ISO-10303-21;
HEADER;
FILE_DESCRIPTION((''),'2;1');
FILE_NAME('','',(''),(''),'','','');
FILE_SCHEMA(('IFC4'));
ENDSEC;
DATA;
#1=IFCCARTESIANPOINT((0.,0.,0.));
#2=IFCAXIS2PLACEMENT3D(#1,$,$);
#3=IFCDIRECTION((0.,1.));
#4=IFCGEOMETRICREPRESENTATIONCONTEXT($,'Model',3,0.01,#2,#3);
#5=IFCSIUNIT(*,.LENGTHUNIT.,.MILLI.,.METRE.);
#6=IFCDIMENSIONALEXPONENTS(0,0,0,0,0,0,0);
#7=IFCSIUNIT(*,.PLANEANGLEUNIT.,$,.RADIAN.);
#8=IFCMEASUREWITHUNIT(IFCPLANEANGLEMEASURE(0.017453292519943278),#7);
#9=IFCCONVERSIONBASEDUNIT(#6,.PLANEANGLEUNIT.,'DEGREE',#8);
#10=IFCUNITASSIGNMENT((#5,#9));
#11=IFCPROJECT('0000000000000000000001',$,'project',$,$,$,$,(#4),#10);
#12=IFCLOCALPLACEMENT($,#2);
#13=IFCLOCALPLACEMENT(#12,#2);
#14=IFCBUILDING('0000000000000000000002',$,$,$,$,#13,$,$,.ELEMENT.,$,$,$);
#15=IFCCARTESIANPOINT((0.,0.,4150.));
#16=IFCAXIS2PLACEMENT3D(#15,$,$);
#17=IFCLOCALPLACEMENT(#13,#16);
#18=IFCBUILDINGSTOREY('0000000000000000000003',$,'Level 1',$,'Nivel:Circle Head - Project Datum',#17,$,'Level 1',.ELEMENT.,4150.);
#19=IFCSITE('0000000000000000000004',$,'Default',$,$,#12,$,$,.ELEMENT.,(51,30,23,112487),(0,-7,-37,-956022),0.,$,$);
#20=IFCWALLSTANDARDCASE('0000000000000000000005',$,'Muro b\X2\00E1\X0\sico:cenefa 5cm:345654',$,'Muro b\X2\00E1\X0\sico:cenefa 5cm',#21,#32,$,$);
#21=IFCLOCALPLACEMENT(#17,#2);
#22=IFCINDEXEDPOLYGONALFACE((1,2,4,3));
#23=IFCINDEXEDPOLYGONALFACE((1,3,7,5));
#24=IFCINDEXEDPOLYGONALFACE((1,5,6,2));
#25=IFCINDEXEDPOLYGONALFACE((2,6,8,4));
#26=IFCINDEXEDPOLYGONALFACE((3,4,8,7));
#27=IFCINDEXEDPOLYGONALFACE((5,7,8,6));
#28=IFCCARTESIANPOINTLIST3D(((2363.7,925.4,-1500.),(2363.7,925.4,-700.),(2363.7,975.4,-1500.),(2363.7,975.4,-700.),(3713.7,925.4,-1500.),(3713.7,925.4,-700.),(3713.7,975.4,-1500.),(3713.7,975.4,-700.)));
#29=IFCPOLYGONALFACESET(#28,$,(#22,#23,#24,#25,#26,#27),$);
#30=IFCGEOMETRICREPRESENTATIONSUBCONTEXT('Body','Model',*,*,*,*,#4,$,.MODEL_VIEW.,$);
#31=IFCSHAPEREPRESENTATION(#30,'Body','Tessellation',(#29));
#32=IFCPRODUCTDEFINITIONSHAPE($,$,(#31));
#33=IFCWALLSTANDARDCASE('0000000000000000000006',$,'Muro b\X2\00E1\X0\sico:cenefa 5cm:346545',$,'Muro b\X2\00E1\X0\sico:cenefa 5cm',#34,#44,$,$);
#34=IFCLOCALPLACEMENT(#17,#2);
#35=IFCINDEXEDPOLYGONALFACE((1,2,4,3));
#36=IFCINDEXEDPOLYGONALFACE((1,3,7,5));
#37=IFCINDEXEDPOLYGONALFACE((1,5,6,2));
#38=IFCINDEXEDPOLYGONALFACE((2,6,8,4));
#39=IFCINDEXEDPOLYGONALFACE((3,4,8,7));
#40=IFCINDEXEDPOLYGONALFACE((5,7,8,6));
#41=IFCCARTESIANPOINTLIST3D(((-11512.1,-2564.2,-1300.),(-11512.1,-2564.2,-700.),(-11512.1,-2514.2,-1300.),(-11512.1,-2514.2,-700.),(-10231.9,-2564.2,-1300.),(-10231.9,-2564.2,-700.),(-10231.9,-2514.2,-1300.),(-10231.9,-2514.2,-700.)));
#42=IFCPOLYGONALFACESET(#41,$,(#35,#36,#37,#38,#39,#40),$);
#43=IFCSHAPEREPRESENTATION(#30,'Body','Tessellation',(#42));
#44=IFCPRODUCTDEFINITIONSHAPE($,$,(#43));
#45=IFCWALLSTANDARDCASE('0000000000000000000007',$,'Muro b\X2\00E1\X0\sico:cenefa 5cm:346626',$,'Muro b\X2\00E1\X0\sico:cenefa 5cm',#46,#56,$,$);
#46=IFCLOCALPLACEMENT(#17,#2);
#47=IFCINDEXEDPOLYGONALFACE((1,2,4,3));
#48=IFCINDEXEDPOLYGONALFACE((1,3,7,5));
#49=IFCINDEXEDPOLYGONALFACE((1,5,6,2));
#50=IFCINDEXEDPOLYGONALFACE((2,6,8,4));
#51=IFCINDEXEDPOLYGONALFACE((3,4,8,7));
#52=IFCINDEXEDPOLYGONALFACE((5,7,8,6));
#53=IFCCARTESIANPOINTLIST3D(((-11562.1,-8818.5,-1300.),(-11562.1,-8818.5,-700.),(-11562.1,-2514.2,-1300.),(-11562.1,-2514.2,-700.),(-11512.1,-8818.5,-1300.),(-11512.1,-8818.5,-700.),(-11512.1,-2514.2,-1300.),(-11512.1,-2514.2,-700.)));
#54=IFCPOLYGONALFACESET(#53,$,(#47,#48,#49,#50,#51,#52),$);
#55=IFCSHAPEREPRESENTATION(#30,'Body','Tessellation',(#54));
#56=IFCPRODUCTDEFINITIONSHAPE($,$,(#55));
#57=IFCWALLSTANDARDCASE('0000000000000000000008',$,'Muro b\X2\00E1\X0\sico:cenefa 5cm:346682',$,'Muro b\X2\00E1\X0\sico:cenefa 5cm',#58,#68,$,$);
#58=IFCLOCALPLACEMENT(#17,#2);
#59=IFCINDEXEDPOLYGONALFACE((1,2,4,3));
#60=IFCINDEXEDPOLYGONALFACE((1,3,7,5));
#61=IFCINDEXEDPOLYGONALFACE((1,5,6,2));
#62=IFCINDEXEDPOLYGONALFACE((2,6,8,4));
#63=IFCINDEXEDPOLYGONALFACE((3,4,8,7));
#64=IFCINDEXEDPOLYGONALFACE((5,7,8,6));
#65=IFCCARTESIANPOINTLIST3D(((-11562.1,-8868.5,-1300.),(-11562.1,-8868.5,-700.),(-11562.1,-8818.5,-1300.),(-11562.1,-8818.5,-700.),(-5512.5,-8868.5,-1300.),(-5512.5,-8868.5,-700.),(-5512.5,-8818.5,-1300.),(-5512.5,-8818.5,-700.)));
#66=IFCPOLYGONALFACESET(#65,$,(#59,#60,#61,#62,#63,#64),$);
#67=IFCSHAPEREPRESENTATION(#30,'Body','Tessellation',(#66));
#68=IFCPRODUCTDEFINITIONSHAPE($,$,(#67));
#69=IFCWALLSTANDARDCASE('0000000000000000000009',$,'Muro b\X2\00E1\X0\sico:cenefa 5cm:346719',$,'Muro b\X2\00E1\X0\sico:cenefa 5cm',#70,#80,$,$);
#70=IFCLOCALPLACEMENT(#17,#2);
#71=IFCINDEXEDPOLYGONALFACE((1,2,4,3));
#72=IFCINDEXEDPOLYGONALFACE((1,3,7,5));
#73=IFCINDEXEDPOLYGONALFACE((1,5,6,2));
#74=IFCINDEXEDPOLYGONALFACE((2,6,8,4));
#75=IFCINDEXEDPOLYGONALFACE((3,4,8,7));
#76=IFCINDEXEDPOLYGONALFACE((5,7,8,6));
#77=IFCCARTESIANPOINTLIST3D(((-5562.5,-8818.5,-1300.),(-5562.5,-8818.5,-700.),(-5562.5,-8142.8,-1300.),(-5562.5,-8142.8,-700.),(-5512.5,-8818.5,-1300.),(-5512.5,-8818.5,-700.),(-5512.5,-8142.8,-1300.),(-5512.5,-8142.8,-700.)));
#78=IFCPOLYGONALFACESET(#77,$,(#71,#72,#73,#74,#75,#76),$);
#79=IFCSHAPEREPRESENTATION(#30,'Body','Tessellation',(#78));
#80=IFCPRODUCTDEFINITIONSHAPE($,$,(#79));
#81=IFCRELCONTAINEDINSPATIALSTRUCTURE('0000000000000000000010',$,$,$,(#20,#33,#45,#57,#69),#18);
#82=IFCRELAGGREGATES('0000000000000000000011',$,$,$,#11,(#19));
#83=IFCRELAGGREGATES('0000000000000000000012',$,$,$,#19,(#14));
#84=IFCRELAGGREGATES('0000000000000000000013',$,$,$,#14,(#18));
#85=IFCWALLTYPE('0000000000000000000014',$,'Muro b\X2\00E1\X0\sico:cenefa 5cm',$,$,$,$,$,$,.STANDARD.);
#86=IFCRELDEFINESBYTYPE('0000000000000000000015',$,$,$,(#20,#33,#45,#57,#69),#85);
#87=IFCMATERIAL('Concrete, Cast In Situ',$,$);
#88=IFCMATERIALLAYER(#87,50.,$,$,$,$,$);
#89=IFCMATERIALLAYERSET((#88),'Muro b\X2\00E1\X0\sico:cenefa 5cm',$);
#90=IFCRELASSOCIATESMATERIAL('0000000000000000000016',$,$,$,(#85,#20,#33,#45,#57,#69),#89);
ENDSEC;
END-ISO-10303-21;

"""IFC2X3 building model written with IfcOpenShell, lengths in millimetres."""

from ifc_helpers import new_model, entity, si_unit, converted_unit, direction, frame, frame_2d, origin, place, context, subcontext, project, spatial, rectangle, extrude, material, layer, layer_set, layer_usage, type_object, element, save


model = new_model("IFC2X3")

# Units and contexts
model_context = context("Model", 3, precision=0.01, world=origin(), true_north=direction((0.0, 1.0)))
body_context = subcontext(model_context, "Body", "Model", "MODEL_VIEW")
ifc_project = project(units=[si_unit("LENGTHUNIT", "METRE", prefix="MILLI"), converted_unit("PLANEANGLEUNIT", "DEGREE", entity("IfcPlaneAngleMeasure", 0.017453292519943278), si_unit("PLANEANGLEUNIT", "RADIAN"), dimensions=[0, 0, 0, 0, 0, 0, 0])], contexts=[model_context])

# Site, building, storey
site_placement = place(None, origin())
site = spatial("IfcSite", under=ifc_project, at=site_placement, Name="Default", CompositionType="ELEMENT", RefLatitude=(51, 30, 23, 112487), RefLongitude=(0, -7, -37, -956022), RefElevation=0.0)
building_placement = place(site_placement, origin())
building = spatial("IfcBuilding", under=site, at=building_placement, CompositionType="ELEMENT")
storey_placement = place(building_placement, frame((0.0, 0.0, 4150.0)))
storey = spatial("IfcBuildingStorey", under=building, at=storey_placement, Name="Level 1", ObjectType="Nivel:Circle Head - Project Datum", LongName="Level 1", CompositionType="ELEMENT", Elevation=4150.0)

# Walls
ifc_material_1 = material(Name="Concrete, Cast In Situ")
ifc_layer_1 = layer(ifc_material_1, 50.0)
ifc_layer_set_1 = layer_set([ifc_layer_1], Name="Muro básico:cenefa 5cm")
wall_type = type_object("IfcWallType", Name="Muro básico:cenefa 5cm", PredefinedType="STANDARD", material=ifc_layer_set_1)
ifc_layer_usage_1 = layer_usage(ifc_layer_set_1, "AXIS2", "NEGATIVE", 25.0)
wall_1_placement = place(storey_placement, frame((3713.7, 950.4, -1500.0), z_axis=(0.0, 0.0, 1.0), x_axis=(-1.0, 0.0, 0.0)))
element("IfcWallStandardCase", 1, at=wall_1_placement, inside=storey, type_object=wall_type, material=ifc_layer_usage_1, Name="Muro básico:cenefa 5cm:345654", ObjectType="Muro básico:cenefa 5cm", context=body_context, shape_type="SweptSolid", body=[
    extrude(rectangle(XDim=1350.0, YDim=50.0, at=frame_2d((675.0, 0.0), x_axis=(-1.0, 0.0))), origin(), (0.0, 0.0, 1.0), 800.0),
])
ifc_layer_usage_2 = layer_usage(ifc_layer_set_1, "AXIS2", "NEGATIVE", 25.0)
wall_2_placement = place(storey_placement, frame((-10231.9, -2539.2, -1300.0), z_axis=(0.0, 0.0, 1.0), x_axis=(-1.0, 0.0, 0.0)))
element("IfcWallStandardCase", 2, at=wall_2_placement, inside=storey, type_object=wall_type, material=ifc_layer_usage_2, Name="Muro básico:cenefa 5cm:346545", ObjectType="Muro básico:cenefa 5cm", context=body_context, shape_type="SweptSolid", body=[
    extrude(rectangle(XDim=1280.2, YDim=50.0, at=frame_2d((640.1, 0.0), x_axis=(-1.0, 0.0))), origin(), (0.0, 0.0, 1.0), 600.0),
])
ifc_layer_usage_3 = layer_usage(ifc_layer_set_1, "AXIS2", "NEGATIVE", 25.0)
wall_3_placement = place(storey_placement, frame((-11537.1, -2514.2, -1300.0), z_axis=(0.0, 0.0, 1.0), x_axis=(0.0, -1.0, 0.0)))
element("IfcWallStandardCase", 3, at=wall_3_placement, inside=storey, type_object=wall_type, material=ifc_layer_usage_3, Name="Muro básico:cenefa 5cm:346626", ObjectType="Muro básico:cenefa 5cm", context=body_context, shape_type="SweptSolid", body=[
    extrude(rectangle(XDim=6304.3, YDim=50.0, at=frame_2d((3152.1, 0.0), x_axis=(-1.0, 0.0))), origin(), (0.0, 0.0, 1.0), 600.0),
])
ifc_layer_usage_4 = layer_usage(ifc_layer_set_1, "AXIS2", "NEGATIVE", 25.0)
wall_4_placement = place(storey_placement, frame((-11562.1, -8843.5, -1300.0)))
element("IfcWallStandardCase", 4, at=wall_4_placement, inside=storey, type_object=wall_type, material=ifc_layer_usage_4, Name="Muro básico:cenefa 5cm:346682", ObjectType="Muro básico:cenefa 5cm", context=body_context, shape_type="SweptSolid", body=[
    extrude(rectangle(XDim=6049.7, YDim=50.0, at=frame_2d((3024.8, 0.0), x_axis=(-1.0, 0.0))), origin(), (0.0, 0.0, 1.0), 600.0),
])
ifc_layer_usage_5 = layer_usage(ifc_layer_set_1, "AXIS2", "NEGATIVE", 25.0)
wall_5_placement = place(storey_placement, frame((-5537.5, -8818.5, -1300.0), z_axis=(0.0, 0.0, 1.0), x_axis=(0.0, 1.0, 0.0)))
element("IfcWallStandardCase", 5, at=wall_5_placement, inside=storey, type_object=wall_type, material=ifc_layer_usage_5, Name="Muro básico:cenefa 5cm:346719", ObjectType="Muro básico:cenefa 5cm", context=body_context, shape_type="SweptSolid", body=[
    extrude(rectangle(XDim=675.7, YDim=50.0, at=frame_2d((337.9, 0.0), x_axis=(-1.0, 0.0))), origin(), (0.0, 0.0, 1.0), 600.0),
])

save(model, "model.ifc")
